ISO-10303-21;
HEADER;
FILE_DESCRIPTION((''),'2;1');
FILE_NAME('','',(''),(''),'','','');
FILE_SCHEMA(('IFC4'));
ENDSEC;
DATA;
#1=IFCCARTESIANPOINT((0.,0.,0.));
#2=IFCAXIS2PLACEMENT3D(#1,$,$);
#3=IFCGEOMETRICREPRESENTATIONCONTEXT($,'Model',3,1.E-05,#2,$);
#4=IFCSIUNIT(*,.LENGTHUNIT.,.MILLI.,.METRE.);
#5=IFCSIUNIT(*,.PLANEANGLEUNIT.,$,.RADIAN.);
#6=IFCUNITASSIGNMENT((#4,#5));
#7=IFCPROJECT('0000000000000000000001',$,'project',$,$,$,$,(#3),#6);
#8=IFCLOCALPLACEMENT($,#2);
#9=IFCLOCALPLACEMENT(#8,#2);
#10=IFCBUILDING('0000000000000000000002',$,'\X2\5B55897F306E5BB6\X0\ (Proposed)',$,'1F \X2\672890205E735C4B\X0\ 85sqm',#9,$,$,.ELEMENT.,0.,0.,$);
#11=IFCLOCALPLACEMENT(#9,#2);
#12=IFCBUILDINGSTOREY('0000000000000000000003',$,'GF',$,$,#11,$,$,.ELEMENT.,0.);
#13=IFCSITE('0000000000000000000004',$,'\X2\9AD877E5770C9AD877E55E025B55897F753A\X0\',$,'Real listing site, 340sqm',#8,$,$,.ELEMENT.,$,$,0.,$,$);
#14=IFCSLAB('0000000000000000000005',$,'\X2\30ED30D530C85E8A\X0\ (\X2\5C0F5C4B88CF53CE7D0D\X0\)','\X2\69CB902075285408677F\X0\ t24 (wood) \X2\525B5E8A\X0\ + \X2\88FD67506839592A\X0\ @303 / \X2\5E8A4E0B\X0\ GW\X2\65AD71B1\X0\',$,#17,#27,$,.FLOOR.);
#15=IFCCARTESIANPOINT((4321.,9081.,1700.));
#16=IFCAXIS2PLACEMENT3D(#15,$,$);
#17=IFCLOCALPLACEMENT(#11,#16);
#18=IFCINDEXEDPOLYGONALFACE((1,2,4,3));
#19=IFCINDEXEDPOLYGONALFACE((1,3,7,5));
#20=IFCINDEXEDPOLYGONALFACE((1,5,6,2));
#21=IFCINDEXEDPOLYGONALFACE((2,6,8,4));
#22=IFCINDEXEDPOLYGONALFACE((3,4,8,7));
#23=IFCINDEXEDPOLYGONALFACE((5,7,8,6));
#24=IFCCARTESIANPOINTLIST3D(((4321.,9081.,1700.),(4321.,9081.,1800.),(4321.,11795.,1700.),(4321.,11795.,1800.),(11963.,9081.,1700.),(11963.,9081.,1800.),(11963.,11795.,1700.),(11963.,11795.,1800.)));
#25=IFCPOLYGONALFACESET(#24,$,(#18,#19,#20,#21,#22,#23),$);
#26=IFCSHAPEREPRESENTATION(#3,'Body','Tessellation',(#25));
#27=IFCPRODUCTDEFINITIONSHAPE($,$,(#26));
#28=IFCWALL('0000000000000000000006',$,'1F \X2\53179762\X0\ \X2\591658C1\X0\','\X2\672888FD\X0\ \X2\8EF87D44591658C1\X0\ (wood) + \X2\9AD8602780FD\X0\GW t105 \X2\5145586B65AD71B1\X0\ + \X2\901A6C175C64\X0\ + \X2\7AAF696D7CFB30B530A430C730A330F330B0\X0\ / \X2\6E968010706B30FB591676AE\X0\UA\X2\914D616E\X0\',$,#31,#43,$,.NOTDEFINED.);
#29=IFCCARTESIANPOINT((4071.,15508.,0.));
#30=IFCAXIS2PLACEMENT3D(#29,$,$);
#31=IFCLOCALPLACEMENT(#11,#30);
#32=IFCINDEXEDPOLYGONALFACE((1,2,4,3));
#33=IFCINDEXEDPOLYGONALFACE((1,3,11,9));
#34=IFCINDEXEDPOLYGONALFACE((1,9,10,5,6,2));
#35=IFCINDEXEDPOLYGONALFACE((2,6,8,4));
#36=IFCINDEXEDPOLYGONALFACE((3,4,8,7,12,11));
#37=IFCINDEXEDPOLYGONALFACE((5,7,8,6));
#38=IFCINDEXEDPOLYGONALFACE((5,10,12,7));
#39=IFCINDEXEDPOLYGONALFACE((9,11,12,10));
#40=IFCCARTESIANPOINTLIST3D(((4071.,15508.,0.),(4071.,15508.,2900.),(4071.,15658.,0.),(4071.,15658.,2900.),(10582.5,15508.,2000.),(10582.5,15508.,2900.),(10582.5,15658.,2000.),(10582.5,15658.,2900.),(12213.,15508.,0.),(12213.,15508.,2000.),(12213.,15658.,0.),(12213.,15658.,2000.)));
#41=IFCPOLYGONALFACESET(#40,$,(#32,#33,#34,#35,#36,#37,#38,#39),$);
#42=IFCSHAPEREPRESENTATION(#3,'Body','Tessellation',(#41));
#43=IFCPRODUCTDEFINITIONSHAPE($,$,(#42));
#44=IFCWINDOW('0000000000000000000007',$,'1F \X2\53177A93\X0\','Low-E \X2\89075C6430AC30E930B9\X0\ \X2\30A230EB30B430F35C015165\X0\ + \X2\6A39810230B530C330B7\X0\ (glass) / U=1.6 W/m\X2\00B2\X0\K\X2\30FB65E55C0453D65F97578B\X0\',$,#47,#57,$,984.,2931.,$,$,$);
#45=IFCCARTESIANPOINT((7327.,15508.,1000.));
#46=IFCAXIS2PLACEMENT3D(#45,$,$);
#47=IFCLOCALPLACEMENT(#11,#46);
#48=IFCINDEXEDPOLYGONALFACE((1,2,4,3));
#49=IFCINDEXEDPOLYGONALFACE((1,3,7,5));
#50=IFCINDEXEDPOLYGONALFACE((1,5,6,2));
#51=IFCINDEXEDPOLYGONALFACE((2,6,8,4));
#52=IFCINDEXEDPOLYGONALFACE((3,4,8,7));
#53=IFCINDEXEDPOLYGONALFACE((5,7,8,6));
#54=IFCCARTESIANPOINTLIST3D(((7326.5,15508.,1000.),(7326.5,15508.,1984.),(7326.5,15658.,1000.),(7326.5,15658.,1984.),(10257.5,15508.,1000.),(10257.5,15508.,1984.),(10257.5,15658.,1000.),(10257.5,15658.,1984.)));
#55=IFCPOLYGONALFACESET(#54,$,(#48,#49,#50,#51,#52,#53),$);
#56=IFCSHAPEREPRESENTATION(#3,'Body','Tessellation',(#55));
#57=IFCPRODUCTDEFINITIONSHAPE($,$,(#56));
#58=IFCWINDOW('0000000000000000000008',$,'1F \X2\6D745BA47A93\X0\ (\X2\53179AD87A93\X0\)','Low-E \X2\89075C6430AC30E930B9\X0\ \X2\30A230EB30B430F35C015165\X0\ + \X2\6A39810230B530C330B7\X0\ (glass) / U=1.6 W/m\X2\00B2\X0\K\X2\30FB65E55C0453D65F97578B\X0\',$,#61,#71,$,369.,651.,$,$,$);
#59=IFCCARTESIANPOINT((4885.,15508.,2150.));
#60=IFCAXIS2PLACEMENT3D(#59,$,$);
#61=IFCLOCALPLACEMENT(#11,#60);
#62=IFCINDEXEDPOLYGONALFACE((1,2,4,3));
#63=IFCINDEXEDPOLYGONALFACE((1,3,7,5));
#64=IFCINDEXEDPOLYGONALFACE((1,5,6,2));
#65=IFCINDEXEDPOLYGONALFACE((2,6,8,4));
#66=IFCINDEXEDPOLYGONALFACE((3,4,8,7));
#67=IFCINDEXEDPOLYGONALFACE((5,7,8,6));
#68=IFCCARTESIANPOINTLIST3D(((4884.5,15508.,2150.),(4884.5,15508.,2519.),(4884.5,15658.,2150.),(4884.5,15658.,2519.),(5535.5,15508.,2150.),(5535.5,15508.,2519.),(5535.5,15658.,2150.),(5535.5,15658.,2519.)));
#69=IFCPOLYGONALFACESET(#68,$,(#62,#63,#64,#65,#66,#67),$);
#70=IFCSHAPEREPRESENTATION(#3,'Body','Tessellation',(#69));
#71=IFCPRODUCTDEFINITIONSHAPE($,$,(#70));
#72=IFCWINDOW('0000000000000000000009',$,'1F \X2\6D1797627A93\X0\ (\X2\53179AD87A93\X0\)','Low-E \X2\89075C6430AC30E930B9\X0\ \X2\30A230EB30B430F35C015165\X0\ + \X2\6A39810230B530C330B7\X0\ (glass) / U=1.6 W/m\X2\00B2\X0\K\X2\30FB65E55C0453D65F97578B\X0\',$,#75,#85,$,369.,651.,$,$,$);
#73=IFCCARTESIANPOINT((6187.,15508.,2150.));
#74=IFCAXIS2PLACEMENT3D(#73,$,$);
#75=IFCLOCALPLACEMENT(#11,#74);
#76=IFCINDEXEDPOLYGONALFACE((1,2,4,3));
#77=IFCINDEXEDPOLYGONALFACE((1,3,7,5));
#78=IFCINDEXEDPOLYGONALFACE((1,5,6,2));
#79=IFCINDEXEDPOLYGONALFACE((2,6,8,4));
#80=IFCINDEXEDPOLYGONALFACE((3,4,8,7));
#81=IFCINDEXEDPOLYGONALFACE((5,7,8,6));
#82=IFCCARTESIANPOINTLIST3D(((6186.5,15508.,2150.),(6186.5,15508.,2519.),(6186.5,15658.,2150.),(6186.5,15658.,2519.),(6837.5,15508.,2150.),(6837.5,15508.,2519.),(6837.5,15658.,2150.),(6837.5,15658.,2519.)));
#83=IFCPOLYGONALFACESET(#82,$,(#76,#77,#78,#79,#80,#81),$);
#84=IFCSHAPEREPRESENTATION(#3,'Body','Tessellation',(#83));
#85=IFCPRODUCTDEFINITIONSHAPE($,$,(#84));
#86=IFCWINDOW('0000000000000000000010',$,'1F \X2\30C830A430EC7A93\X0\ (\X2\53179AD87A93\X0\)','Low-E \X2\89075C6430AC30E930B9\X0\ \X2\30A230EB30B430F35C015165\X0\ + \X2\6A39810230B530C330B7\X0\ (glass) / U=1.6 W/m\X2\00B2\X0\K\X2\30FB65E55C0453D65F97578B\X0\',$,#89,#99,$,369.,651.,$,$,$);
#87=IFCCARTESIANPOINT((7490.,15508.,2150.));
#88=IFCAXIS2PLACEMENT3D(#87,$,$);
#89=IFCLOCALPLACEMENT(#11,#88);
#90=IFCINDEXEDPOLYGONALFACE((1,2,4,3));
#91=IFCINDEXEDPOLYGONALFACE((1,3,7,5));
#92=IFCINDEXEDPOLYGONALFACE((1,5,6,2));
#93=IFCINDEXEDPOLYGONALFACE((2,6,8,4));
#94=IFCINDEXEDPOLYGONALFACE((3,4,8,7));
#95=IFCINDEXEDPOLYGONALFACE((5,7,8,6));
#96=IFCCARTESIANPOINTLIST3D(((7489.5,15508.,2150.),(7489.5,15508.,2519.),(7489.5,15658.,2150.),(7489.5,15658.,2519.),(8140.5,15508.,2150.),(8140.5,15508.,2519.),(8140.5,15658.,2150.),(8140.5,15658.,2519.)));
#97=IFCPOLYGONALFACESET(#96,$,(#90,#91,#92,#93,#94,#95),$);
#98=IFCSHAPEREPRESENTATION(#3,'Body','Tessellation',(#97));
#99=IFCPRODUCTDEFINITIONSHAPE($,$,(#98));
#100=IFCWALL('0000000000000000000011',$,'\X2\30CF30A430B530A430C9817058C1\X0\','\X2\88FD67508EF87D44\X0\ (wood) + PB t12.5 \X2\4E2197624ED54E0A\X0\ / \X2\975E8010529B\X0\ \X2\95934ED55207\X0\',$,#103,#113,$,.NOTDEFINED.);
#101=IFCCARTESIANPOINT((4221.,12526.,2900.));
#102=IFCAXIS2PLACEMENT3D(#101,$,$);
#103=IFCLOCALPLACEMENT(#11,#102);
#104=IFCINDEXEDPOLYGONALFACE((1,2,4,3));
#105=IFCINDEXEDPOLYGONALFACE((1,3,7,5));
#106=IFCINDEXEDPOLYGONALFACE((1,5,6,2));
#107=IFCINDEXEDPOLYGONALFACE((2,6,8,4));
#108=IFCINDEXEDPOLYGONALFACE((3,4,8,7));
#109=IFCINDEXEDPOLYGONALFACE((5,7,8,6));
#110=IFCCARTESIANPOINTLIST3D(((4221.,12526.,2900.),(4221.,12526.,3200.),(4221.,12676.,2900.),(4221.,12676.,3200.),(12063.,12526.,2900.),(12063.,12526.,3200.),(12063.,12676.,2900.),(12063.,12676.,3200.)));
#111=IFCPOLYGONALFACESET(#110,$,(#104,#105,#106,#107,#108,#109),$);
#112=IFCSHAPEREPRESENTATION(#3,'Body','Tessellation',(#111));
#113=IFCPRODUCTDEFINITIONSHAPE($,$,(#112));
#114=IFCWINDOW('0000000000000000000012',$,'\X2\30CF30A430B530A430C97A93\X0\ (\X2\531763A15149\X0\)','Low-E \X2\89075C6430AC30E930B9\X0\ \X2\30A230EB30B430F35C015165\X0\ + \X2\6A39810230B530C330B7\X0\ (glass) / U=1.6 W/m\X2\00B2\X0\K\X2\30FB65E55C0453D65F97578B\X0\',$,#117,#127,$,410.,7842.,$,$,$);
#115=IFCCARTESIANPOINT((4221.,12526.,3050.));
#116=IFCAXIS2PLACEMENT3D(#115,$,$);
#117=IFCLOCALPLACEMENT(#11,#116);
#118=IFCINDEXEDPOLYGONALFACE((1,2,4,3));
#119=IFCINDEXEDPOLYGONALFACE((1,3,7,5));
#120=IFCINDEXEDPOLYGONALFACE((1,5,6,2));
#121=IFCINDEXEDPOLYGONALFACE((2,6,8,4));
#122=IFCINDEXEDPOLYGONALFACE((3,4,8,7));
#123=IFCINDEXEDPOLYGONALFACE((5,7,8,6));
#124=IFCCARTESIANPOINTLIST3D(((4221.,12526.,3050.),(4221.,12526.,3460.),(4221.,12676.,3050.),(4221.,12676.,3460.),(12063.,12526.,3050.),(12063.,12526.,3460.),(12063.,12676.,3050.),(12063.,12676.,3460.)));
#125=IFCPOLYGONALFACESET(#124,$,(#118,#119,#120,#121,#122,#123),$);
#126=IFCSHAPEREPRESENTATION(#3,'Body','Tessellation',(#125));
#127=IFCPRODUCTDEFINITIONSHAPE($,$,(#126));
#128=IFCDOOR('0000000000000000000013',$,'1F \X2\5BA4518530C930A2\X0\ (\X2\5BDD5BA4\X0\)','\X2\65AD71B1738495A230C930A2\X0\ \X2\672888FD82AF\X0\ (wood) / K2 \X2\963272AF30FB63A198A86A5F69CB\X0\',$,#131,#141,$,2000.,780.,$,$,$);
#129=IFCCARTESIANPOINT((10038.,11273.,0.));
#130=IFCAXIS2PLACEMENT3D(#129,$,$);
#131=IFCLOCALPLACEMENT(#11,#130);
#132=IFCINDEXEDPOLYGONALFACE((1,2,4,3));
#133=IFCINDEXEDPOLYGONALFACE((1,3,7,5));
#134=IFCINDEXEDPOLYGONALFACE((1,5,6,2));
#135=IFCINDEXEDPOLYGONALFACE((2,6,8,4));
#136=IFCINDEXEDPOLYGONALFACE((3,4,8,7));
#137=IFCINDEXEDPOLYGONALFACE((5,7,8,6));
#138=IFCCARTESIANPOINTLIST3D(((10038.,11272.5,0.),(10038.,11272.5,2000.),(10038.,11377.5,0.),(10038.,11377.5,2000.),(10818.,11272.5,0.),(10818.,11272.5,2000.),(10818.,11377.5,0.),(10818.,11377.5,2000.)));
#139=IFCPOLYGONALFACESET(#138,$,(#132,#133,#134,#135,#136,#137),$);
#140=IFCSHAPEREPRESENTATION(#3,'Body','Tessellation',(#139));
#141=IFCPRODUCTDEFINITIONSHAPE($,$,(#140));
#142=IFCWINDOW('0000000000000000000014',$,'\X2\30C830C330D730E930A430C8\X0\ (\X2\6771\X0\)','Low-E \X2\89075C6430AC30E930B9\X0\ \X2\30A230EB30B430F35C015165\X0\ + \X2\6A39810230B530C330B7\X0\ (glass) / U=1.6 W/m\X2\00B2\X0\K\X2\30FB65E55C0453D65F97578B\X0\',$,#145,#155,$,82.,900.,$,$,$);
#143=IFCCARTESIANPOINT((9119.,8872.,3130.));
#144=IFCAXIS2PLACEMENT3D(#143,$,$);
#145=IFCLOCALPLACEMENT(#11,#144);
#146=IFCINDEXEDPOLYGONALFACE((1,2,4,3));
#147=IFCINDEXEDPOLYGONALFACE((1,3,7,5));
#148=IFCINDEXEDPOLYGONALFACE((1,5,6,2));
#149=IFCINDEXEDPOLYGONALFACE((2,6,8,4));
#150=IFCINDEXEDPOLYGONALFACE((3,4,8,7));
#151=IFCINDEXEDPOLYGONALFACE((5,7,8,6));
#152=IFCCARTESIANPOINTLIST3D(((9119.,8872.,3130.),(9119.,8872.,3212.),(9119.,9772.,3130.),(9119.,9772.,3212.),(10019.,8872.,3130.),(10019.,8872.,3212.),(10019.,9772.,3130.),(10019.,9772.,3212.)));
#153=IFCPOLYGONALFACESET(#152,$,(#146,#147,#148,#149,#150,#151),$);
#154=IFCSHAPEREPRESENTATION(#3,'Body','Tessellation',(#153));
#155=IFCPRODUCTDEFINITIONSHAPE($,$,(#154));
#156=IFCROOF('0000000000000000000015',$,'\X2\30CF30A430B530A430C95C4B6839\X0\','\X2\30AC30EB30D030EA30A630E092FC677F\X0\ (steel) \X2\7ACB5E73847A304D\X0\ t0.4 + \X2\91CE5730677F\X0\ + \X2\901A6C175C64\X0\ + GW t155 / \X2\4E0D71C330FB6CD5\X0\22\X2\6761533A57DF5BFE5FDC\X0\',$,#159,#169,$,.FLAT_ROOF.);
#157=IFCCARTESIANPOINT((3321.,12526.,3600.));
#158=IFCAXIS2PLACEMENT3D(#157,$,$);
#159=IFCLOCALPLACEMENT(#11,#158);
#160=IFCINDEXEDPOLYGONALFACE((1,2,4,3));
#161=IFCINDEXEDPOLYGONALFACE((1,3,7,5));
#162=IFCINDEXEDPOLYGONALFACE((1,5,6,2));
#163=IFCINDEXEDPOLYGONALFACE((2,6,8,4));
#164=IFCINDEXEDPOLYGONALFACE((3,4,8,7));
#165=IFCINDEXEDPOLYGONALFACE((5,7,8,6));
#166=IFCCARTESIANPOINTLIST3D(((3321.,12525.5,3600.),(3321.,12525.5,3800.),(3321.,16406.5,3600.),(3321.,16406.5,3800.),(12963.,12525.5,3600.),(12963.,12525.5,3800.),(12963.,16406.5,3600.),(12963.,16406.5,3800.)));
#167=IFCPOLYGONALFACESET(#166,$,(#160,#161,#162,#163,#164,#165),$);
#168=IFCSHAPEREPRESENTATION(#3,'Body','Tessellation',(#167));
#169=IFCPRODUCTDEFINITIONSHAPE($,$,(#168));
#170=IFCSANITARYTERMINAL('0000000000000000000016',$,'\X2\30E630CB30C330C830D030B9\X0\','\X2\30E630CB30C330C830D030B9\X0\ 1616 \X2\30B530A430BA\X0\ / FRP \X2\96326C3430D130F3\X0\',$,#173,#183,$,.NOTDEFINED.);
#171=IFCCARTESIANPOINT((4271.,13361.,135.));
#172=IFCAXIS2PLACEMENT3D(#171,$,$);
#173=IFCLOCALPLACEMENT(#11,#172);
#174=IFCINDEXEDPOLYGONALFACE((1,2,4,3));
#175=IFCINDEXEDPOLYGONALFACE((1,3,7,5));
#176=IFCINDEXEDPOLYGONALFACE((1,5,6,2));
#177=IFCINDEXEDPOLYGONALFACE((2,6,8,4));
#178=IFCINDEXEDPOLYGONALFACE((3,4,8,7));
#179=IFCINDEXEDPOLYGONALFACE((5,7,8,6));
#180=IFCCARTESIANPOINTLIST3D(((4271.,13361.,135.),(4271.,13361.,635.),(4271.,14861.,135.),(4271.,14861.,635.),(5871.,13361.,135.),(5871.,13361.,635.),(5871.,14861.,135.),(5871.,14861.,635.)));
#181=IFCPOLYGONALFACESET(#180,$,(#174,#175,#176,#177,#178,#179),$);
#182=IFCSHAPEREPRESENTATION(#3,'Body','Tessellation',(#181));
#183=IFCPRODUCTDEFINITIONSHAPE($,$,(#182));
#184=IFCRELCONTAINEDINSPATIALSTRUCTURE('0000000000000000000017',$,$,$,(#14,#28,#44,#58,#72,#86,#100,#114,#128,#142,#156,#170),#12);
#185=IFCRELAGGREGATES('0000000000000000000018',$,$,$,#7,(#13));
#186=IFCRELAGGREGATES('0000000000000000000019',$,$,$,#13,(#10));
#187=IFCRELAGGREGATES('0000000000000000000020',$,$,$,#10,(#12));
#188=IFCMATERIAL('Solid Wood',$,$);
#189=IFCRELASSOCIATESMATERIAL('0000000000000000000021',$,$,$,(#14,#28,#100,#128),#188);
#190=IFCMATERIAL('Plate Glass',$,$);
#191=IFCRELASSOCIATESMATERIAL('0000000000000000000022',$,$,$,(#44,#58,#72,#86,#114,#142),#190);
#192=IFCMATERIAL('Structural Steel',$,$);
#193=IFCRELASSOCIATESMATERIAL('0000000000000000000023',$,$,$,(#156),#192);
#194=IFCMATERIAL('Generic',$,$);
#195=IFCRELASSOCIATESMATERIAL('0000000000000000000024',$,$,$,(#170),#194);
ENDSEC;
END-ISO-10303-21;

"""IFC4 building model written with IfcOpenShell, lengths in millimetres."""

from ifc_helpers import new_model, si_unit, frame, frame_2d, origin, place, context, project, spatial, rectangle, extrude, material, element, fill, save


model = new_model("IFC4")

# Units and contexts
model_context = context("Model", 3, precision=1e-05, world=origin())
ifc_project = project(units=[si_unit("LENGTHUNIT", "METRE", prefix="MILLI"), si_unit("PLANEANGLEUNIT", "RADIAN")], contexts=[model_context])

# Site, building, storey
site_placement = place(None, origin())
site = spatial("IfcSite", under=ifc_project, at=site_placement, Name="高知県高知市孕西町", ObjectType="Real listing site, 340sqm", CompositionType="ELEMENT", RefElevation=0.0)
building_placement = place(site_placement, origin())
building = spatial("IfcBuilding", under=site, at=building_placement, Name="孕西の家 (Proposed)", ObjectType="1F 木造平屋 85sqm", CompositionType="ELEMENT", ElevationOfRefHeight=0.0, ElevationOfTerrain=0.0)
storey_placement = place(building_placement, origin())
storey = spatial("IfcBuildingStorey", under=building, at=storey_placement, Name="GF", CompositionType="ELEMENT", Elevation=0.0)

# Slab
ifc_material_1 = material(Name="Solid Wood")
slab_placement = place(storey_placement, frame((4321.0, 9081.0, 1700.0)))
element("IfcSlab", 1, at=slab_placement, inside=storey, material=ifc_material_1, Name="ロフト床 (小屋裏収納)", Description="構造用合板 t24 (wood) 剛床 + 製材根太 @303 / 床下 GW断熱", PredefinedType="FLOOR", context=model_context, shape_type="SweptSolid", body=[
    extrude(rectangle(XDim=7642.0, YDim=2714.0, at=frame_2d((3821.0, 1357.0))), frame((4321.0, 9081.0, 1700.0)), (0.0, 0.0, 1.0), 100.0),
])

# Wall, openings, windows
wall_1_placement = place(storey_placement, frame((4071.0, 15508.0, 0.0)))
wall_1 = element("IfcWall", 2, at=wall_1_placement, inside=storey, material=ifc_material_1, Name="1F 北面 外壁", Description="木製 軸組外壁 (wood) + 高性能GW t105 充填断熱 + 通気層 + 窯業系サイディング / 準耐火・外皮UA配慮", PredefinedType="NOTDEFINED", context=model_context, shape_type="SweptSolid", body=[
    extrude(rectangle(XDim=8142.0, YDim=150.0, at=frame_2d((4071.0, 75.0))), frame((4071.0, 15508.0, 0.0)), (0.0, 0.0, 1.0), 2900.0),
])
opening_1_placement = place(storey_placement, frame((7327.0, 15508.0, 1000.0)))
opening_1 = element("IfcOpeningElement", 3, at=opening_1_placement, cuts=wall_1, PredefinedType="NOTDEFINED", context=model_context, shape_type="SweptSolid", body=[
    extrude(rectangle(XDim=2931.0, YDim=150.0, at=frame_2d((1465.0, 75.0))), frame((7327.0, 15508.0, 1000.0)), (0.0, 0.0, 1.0), 984.0),
])
opening_2_placement = place(storey_placement, frame((4885.0, 15508.0, 2150.0)))
opening_2 = element("IfcOpeningElement", 4, at=opening_2_placement, cuts=wall_1, PredefinedType="NOTDEFINED", context=model_context, shape_type="SweptSolid", body=[
    extrude(rectangle(XDim=651.0, YDim=150.0, at=frame_2d((325.0, 75.0))), frame((4885.0, 15508.0, 2150.0)), (0.0, 0.0, 1.0), 369.0),
])
opening_3_placement = place(storey_placement, frame((6187.0, 15508.0, 2150.0)))
opening_3 = element("IfcOpeningElement", 5, at=opening_3_placement, cuts=wall_1, PredefinedType="NOTDEFINED", context=model_context, shape_type="SweptSolid", body=[
    extrude(rectangle(XDim=651.0, YDim=150.0, at=frame_2d((325.0, 75.0))), frame((6187.0, 15508.0, 2150.0)), (0.0, 0.0, 1.0), 369.0),
])
opening_4_placement = place(storey_placement, frame((7490.0, 15508.0, 2150.0)))
opening_4 = element("IfcOpeningElement", 6, at=opening_4_placement, cuts=wall_1, PredefinedType="NOTDEFINED", context=model_context, shape_type="SweptSolid", body=[
    extrude(rectangle(XDim=651.0, YDim=150.0, at=frame_2d((325.0, 75.0))), frame((7490.0, 15508.0, 2150.0)), (0.0, 0.0, 1.0), 369.0),
])
ifc_material_2 = material(Name="Plate Glass")
window_1_placement = place(storey_placement, frame((7327.0, 15508.0, 1000.0)))
window_1 = element("IfcWindow", 7, at=window_1_placement, inside=storey, material=ifc_material_2, Name="1F 北窓", Description="Low-E 複層ガラス アルゴン封入 + 樹脂サッシ (glass) / U=1.6 W/m²K・日射取得型", OverallHeight=984.0, OverallWidth=2931.0, context=model_context, shape_type="SweptSolid", body=[
    extrude(rectangle(XDim=2931.0, YDim=150.0, at=frame_2d((1465.0, 75.0))), frame((7327.0, 15508.0, 1000.0)), (0.0, 0.0, 1.0), 984.0),
])
fill(opening_1, window_1)
window_2_placement = place(storey_placement, frame((4885.0, 15508.0, 2150.0)))
window_2 = element("IfcWindow", 8, at=window_2_placement, inside=storey, material=ifc_material_2, Name="1F 浴室窓 (北高窓)", Description="Low-E 複層ガラス アルゴン封入 + 樹脂サッシ (glass) / U=1.6 W/m²K・日射取得型", OverallHeight=369.0, OverallWidth=651.0, context=model_context, shape_type="SweptSolid", body=[
    extrude(rectangle(XDim=651.0, YDim=150.0, at=frame_2d((325.0, 75.0))), frame((4885.0, 15508.0, 2150.0)), (0.0, 0.0, 1.0), 369.0),
])
fill(opening_2, window_2)
window_3_placement = place(storey_placement, frame((6187.0, 15508.0, 2150.0)))
window_3 = element("IfcWindow", 9, at=window_3_placement, inside=storey, material=ifc_material_2, Name="1F 洗面窓 (北高窓)", Description="Low-E 複層ガラス アルゴン封入 + 樹脂サッシ (glass) / U=1.6 W/m²K・日射取得型", OverallHeight=369.0, OverallWidth=651.0, context=model_context, shape_type="SweptSolid", body=[
    extrude(rectangle(XDim=651.0, YDim=150.0, at=frame_2d((325.0, 75.0))), frame((6187.0, 15508.0, 2150.0)), (0.0, 0.0, 1.0), 369.0),
])
fill(opening_3, window_3)
window_4_placement = place(storey_placement, frame((7490.0, 15508.0, 2150.0)))
window_4 = element("IfcWindow", 10, at=window_4_placement, inside=storey, material=ifc_material_2, Name="1F トイレ窓 (北高窓)", Description="Low-E 複層ガラス アルゴン封入 + 樹脂サッシ (glass) / U=1.6 W/m²K・日射取得型", OverallHeight=369.0, OverallWidth=651.0, context=model_context, shape_type="SweptSolid", body=[
    extrude(rectangle(XDim=651.0, YDim=150.0, at=frame_2d((325.0, 75.0))), frame((7490.0, 15508.0, 2150.0)), (0.0, 0.0, 1.0), 369.0),
])
fill(opening_4, window_4)

# Wall, opening, window
wall_2_placement = place(storey_placement, frame((4221.0, 12526.0, 2900.0)))
wall_2 = element("IfcWall", 11, at=wall_2_placement, inside=storey, material=ifc_material_1, Name="ハイサイド腰壁", Description="製材軸組 (wood) + PB t12.5 両面仕上 / 非耐力 間仕切", PredefinedType="NOTDEFINED", context=model_context, shape_type="SweptSolid", body=[
    extrude(rectangle(XDim=7842.0, YDim=150.0, at=frame_2d((3921.0, 75.0))), frame((4221.0, 12526.0, 2900.0)), (0.0, 0.0, 1.0), 700.0),
])
opening_5_placement = place(storey_placement, frame((4221.0, 12526.0, 3050.0)))
opening_5 = element("IfcOpeningElement", 12, at=opening_5_placement, cuts=wall_2, PredefinedType="NOTDEFINED", context=model_context, shape_type="SweptSolid", body=[
    extrude(rectangle(XDim=7842.0, YDim=150.0, at=frame_2d((3921.0, 75.0))), frame((4221.0, 12526.0, 3050.0)), (0.0, 0.0, 1.0), 410.0),
])
window_5_placement = place(storey_placement, frame((4221.0, 12526.0, 3050.0)))
window_5 = element("IfcWindow", 13, at=window_5_placement, inside=storey, material=ifc_material_2, Name="ハイサイド窓 (北採光)", Description="Low-E 複層ガラス アルゴン封入 + 樹脂サッシ (glass) / U=1.6 W/m²K・日射取得型", OverallHeight=410.0, OverallWidth=7842.0, context=model_context, shape_type="SweptSolid", body=[
    extrude(rectangle(XDim=7842.0, YDim=150.0, at=frame_2d((3921.0, 75.0))), frame((4221.0, 12526.0, 3050.0)), (0.0, 0.0, 1.0), 410.0),
])
fill(opening_5, window_5)

# Door
door_1_placement = place(storey_placement, frame((10038.0, 11273.0, 0.0)))
element("IfcDoor", 14, at=door_1_placement, inside=storey, material=ifc_material_1, Name="1F 室内ドア (寝室)", Description="断熱玄関ドア 木製芯 (wood) / K2 防犯・採風機構", OverallHeight=2000.0, OverallWidth=780.0, context=model_context, shape_type="SweptSolid", body=[
    extrude(rectangle(XDim=780.0, YDim=105.0, at=frame_2d((390.0, 52.0))), frame((10038.0, 11273.0, 0.0)), (0.0, 0.0, 1.0), 2000.0),
])

# Window
window_6_placement = place(storey_placement, frame((9119.0, 8872.0, 3130.0)))
element("IfcWindow", 15, at=window_6_placement, inside=storey, material=ifc_material_2, Name="トップライト (東)", Description="Low-E 複層ガラス アルゴン封入 + 樹脂サッシ (glass) / U=1.6 W/m²K・日射取得型", OverallHeight=82.0, OverallWidth=900.0, context=model_context, shape_type="SweptSolid", body=[
    extrude(rectangle(XDim=900.0, YDim=900.0, at=frame_2d((450.0, 450.0))), frame((9119.0, 8872.0, 3130.0)), (0.0, 0.0, 1.0), 82.0),
])

# Roof
ifc_material_3 = material(Name="Structural Steel")
roof_placement = place(storey_placement, frame((3321.0, 12526.0, 3600.0)))
element("IfcRoof", 16, at=roof_placement, inside=storey, material=ifc_material_3, Name="ハイサイド屋根", Description="ガルバリウム鋼板 (steel) 立平葺き t0.4 + 野地板 + 通気層 + GW t155 / 不燃・法22条区域対応", PredefinedType="FLAT_ROOF", context=model_context, shape_type="SweptSolid", body=[
    extrude(rectangle(XDim=9642.0, YDim=3881.0, at=frame_2d((4821.0, 1940.0))), frame((3321.0, 12526.0, 3600.0)), (0.0, 0.0, 1.0), 200.0),
])

# Sanitary terminal
ifc_material_4 = material(Name="Generic")
sanitary_terminal_1_placement = place(storey_placement, frame((4271.0, 13361.0, 135.0)))
element("IfcSanitaryTerminal", 17, at=sanitary_terminal_1_placement, inside=storey, material=ifc_material_4, Name="ユニットバス", Description="ユニットバス 1616 サイズ / FRP 防水パン", PredefinedType="NOTDEFINED", context=model_context, shape_type="SweptSolid", body=[
    extrude(rectangle(XDim=1600.0, YDim=1500.0, at=frame_2d((800.0, 750.0))), frame((4271.0, 13361.0, 135.0)), (0.0, 0.0, 1.0), 500.0),
])

save(model, "model.ifc")
